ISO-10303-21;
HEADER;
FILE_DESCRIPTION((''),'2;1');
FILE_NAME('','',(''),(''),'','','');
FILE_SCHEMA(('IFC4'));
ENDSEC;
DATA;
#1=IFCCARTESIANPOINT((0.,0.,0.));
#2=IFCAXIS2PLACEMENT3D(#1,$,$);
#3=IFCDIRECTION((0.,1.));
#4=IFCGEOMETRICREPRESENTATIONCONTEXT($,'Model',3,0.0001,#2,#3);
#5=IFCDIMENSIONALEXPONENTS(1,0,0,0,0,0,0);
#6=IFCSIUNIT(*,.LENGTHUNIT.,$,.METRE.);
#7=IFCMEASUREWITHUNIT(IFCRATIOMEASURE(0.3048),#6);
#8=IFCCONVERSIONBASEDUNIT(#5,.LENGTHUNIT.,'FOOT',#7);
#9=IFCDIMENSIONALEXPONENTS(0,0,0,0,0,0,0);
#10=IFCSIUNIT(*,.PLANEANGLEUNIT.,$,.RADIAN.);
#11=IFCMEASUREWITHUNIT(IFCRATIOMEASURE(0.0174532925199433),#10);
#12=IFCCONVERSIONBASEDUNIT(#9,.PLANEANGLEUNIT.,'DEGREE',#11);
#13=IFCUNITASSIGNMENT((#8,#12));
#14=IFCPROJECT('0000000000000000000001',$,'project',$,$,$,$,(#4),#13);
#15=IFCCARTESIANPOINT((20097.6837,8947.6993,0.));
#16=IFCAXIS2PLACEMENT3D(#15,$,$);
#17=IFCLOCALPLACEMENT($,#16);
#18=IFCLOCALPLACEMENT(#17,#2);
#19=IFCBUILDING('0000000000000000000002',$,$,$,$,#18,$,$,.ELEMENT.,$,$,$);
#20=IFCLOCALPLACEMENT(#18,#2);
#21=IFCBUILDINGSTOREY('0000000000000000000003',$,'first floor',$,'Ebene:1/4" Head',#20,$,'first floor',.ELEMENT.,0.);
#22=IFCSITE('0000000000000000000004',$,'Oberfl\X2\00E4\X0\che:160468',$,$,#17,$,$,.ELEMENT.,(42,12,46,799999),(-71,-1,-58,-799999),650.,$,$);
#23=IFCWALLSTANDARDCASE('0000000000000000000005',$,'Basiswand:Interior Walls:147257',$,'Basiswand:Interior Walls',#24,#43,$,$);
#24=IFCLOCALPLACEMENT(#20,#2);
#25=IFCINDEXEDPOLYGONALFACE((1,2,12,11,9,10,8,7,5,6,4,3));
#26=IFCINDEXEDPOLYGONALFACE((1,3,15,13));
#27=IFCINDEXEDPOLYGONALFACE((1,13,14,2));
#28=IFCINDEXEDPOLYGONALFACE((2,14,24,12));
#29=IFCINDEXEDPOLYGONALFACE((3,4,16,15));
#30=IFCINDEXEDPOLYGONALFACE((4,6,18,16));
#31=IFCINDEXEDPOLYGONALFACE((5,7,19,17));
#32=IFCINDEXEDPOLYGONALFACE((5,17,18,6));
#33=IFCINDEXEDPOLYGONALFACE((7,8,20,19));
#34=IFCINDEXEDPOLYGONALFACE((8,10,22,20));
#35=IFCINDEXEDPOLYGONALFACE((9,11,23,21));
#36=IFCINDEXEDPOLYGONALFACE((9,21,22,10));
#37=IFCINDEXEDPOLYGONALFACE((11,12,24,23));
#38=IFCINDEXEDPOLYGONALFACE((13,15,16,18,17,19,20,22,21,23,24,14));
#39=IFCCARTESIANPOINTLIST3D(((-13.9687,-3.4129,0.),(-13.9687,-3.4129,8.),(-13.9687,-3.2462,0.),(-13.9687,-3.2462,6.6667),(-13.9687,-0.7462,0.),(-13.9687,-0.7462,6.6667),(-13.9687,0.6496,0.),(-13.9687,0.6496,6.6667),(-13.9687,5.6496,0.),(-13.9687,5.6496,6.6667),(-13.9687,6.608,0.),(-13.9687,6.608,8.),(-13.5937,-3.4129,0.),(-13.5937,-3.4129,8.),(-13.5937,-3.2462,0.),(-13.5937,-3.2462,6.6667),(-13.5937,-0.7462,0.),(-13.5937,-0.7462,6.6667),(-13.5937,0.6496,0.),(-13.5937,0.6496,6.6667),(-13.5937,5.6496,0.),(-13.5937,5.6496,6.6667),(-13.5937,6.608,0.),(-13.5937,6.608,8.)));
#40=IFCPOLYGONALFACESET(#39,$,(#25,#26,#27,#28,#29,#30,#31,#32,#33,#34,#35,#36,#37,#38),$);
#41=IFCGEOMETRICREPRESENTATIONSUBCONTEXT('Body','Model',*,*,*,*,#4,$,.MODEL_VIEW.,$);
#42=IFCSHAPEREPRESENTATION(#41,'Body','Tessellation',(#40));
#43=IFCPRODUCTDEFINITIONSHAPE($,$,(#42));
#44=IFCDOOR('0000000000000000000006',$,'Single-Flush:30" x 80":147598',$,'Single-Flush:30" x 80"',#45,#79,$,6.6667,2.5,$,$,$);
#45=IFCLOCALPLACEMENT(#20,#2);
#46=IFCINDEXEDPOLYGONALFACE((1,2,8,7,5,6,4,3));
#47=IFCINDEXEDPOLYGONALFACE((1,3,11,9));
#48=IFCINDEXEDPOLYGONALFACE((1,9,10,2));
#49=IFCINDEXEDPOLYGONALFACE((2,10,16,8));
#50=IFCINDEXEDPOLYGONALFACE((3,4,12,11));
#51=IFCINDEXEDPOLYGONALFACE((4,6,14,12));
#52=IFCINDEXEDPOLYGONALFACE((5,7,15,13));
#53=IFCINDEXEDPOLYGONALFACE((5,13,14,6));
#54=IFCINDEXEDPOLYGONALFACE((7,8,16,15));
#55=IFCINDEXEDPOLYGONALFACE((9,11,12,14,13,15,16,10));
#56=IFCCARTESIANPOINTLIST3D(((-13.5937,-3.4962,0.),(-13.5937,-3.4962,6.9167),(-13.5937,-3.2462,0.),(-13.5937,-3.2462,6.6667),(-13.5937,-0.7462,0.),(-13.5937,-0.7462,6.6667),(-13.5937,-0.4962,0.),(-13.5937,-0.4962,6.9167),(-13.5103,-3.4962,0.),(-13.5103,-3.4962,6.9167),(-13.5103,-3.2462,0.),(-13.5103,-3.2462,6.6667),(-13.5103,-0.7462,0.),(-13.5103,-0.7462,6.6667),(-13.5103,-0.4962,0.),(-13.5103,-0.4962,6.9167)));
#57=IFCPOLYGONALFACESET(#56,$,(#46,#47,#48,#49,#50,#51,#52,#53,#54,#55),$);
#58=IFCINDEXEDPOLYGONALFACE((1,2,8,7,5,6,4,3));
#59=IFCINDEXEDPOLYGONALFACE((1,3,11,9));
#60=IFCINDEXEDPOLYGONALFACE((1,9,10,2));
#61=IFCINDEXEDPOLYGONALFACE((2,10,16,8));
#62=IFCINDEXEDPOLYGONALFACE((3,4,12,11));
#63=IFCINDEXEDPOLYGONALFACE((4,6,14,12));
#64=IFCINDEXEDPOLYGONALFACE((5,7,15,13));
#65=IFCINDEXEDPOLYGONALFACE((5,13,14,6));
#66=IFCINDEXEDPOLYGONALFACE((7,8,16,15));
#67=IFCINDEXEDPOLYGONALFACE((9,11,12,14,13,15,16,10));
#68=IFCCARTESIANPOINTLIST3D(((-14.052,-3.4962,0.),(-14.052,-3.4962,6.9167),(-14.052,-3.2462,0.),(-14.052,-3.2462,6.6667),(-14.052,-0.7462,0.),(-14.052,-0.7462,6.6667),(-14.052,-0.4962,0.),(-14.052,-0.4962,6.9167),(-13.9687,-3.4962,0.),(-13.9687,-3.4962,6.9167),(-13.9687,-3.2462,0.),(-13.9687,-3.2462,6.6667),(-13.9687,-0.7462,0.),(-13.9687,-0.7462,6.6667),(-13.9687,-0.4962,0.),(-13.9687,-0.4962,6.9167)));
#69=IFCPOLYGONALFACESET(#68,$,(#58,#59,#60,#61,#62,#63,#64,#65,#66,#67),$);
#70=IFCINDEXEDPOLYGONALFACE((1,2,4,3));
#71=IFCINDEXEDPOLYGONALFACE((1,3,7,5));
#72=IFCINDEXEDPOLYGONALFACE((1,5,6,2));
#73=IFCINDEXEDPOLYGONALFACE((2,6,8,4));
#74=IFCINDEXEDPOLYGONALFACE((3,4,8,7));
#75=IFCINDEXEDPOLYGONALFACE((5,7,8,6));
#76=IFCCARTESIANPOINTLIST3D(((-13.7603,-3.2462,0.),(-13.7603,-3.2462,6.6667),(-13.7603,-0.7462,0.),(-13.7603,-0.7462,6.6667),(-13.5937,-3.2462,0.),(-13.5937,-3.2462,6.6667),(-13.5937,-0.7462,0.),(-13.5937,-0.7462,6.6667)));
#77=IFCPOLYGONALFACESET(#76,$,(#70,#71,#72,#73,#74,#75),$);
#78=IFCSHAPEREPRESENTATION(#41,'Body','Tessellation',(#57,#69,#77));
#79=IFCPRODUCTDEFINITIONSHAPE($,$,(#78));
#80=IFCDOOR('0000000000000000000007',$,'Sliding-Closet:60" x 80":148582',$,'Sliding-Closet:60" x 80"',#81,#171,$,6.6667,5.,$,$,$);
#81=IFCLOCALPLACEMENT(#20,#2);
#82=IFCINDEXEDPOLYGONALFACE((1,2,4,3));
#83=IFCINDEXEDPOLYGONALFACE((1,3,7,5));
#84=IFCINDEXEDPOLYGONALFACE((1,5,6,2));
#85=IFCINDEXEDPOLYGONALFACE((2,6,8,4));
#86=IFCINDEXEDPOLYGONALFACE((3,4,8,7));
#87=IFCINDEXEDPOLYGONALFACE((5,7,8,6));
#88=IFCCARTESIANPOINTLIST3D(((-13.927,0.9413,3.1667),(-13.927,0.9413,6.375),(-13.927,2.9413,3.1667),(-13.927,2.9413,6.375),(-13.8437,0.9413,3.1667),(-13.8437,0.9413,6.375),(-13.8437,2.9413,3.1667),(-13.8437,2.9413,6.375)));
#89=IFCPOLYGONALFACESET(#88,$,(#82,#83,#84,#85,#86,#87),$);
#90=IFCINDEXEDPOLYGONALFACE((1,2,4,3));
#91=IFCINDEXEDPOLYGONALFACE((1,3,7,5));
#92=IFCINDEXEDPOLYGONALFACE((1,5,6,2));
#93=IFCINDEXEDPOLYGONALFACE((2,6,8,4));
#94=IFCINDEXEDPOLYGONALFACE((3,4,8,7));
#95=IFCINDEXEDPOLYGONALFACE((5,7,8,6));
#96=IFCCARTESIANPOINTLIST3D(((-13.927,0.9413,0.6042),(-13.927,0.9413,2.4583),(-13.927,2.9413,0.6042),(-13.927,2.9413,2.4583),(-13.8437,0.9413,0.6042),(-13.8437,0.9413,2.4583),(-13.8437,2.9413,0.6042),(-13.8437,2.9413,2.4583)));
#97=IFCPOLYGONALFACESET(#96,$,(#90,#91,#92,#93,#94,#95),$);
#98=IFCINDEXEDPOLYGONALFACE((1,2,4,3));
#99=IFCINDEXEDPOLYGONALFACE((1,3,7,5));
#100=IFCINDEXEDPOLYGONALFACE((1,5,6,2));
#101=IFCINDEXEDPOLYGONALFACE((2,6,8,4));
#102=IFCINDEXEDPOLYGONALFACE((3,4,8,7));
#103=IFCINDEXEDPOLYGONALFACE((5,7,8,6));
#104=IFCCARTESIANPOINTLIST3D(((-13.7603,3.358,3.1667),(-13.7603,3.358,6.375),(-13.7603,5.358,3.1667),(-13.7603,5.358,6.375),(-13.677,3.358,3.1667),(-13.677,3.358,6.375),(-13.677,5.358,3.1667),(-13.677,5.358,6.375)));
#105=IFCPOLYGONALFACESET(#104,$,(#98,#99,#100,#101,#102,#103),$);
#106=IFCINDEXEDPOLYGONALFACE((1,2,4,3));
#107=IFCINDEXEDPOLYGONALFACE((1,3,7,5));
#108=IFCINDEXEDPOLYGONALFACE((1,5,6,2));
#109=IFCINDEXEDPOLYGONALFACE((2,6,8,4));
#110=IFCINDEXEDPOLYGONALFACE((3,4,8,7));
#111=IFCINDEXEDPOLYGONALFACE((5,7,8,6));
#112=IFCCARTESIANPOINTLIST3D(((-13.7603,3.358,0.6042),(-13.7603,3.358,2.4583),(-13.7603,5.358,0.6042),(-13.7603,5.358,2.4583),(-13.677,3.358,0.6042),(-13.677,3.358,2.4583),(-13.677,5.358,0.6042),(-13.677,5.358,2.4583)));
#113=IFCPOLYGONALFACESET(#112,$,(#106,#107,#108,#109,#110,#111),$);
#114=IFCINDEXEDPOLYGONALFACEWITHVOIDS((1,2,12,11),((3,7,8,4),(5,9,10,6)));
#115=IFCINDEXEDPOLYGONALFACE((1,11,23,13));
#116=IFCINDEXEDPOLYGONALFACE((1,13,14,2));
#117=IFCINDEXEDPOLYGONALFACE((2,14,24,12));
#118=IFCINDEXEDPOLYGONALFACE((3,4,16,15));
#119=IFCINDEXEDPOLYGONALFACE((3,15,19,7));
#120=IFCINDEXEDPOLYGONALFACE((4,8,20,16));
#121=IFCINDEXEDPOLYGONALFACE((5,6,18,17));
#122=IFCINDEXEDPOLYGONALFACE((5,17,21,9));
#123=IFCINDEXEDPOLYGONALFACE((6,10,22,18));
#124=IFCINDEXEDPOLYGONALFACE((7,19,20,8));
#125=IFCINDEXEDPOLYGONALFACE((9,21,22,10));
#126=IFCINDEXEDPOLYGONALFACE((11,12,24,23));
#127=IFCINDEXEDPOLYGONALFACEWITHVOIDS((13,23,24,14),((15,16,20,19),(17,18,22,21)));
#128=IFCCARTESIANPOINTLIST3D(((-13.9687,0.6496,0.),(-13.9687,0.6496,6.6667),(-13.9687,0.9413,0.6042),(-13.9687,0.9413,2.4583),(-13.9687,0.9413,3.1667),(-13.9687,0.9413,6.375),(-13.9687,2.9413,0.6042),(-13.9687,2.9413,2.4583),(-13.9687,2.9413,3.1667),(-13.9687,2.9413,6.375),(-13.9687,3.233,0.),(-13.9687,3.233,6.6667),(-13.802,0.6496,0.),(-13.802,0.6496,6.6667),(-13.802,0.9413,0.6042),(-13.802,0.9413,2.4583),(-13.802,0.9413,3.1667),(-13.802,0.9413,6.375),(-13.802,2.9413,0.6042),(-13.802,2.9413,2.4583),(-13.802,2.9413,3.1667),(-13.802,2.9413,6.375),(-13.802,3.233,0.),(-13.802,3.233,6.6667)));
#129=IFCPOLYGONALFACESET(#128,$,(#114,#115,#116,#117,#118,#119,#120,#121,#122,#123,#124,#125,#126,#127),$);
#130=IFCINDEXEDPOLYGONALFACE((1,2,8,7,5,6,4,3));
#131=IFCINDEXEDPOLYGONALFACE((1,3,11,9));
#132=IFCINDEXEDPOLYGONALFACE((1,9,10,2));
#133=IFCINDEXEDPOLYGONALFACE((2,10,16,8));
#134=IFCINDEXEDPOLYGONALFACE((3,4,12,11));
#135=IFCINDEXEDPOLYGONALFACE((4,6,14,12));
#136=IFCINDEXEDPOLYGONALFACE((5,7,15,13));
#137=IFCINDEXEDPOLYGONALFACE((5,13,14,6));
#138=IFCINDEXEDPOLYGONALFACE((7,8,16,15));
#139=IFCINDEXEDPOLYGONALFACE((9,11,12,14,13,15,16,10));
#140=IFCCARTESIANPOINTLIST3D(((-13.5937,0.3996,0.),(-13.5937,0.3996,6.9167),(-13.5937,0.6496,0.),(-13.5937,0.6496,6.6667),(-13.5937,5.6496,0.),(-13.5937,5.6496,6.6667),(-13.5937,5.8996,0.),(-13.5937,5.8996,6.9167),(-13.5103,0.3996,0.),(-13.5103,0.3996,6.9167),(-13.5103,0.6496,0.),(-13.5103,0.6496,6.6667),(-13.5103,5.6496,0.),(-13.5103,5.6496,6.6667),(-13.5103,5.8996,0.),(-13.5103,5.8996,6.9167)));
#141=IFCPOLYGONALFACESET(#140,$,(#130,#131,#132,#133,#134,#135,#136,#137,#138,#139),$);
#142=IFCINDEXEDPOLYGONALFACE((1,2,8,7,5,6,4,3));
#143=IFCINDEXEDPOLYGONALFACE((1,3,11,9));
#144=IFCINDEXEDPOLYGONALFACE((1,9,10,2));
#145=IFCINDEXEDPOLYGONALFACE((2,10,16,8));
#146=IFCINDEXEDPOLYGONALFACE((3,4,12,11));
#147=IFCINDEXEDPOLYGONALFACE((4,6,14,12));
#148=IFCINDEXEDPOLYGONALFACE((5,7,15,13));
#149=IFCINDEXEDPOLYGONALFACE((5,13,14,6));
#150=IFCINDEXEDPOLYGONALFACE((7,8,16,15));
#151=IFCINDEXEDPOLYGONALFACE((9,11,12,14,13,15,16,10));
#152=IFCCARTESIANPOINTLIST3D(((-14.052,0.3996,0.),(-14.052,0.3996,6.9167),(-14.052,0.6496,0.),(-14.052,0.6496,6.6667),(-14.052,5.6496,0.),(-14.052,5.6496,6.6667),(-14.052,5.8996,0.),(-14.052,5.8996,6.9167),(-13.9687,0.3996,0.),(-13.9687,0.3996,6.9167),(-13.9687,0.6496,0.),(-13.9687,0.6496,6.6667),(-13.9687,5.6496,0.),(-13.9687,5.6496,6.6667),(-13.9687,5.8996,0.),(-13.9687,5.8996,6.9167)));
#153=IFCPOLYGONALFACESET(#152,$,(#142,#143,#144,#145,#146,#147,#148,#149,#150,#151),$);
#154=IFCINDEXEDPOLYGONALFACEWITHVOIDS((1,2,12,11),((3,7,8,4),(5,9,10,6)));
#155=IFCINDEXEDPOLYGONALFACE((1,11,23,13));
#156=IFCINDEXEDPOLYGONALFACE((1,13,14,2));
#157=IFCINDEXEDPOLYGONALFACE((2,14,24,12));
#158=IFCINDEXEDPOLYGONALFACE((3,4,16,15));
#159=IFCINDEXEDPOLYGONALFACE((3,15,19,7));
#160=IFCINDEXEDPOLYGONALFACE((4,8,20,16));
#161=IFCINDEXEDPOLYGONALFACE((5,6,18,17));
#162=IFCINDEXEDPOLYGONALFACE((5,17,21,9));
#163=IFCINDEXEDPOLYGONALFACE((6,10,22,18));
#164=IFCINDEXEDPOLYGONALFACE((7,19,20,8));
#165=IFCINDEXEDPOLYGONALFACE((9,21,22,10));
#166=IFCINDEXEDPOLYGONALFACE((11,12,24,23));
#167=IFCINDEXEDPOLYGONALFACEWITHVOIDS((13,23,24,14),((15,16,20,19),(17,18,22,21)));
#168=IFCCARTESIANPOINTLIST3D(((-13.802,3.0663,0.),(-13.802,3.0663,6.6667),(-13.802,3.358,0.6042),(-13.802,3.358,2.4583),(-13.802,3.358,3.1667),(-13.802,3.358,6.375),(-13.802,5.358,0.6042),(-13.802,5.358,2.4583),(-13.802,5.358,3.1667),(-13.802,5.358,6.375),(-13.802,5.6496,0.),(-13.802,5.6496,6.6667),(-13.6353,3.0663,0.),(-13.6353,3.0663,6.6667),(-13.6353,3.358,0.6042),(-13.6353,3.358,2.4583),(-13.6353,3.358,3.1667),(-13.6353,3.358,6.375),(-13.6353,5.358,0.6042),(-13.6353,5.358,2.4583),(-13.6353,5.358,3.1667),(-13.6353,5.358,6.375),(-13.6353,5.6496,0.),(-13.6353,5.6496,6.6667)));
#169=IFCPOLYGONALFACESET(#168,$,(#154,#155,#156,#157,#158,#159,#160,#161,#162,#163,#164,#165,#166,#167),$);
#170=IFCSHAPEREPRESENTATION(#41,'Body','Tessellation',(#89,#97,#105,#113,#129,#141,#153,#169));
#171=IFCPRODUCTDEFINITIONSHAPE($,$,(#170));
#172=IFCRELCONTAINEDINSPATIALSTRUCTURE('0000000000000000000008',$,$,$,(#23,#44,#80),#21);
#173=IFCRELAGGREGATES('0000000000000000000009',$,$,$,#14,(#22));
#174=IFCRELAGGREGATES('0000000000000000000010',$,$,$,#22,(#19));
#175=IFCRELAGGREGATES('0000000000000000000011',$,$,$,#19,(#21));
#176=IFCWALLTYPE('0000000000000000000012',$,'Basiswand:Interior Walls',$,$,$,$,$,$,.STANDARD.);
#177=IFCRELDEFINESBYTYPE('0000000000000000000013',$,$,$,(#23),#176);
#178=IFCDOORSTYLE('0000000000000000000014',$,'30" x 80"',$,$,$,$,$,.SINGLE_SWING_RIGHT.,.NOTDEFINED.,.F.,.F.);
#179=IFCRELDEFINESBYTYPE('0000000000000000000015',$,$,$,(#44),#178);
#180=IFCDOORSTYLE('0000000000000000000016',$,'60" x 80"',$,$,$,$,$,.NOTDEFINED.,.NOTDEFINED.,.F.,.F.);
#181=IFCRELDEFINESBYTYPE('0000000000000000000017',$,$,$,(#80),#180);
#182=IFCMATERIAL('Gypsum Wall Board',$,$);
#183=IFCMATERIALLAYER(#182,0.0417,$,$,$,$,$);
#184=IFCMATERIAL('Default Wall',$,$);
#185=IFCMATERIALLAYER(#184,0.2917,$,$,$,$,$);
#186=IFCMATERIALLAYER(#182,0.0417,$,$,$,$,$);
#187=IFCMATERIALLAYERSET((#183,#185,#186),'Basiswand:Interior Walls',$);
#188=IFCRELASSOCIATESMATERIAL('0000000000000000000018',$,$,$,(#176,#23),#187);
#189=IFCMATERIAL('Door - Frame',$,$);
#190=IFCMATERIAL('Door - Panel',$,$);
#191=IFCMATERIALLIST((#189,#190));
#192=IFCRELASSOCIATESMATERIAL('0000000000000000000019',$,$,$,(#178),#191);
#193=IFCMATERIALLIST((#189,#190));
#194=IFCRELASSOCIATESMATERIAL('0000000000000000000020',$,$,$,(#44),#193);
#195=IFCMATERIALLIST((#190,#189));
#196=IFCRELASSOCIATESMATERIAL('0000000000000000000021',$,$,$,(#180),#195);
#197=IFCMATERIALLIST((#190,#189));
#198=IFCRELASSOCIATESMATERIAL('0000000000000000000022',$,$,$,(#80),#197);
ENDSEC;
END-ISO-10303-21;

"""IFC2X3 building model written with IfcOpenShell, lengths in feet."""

from ifc_helpers import new_model, entity, si_unit, converted_unit, direction, frame, frame_2d, origin, origin_2d_with_axis, place, context, subcontext, project, spatial, polyline, rectangle, outline, extrude, source, transform, mapped, material, material_list, layer, layer_set, layer_usage, type_object, type_shapes, element, fill, save


model = new_model("IFC2X3")

# Units and contexts
model_context = context("Model", 3, precision=0.0001, world=origin(), true_north=direction((0.0, 1.0)))
body_context = subcontext(model_context, "Body", "Model", "MODEL_VIEW")
ifc_project = project(units=[converted_unit("LENGTHUNIT", "FOOT", entity("IfcRatioMeasure", 0.3048), si_unit("LENGTHUNIT", "METRE"), dimensions=[1, 0, 0, 0, 0, 0, 0]), converted_unit("PLANEANGLEUNIT", "DEGREE", entity("IfcRatioMeasure", 0.0174532925199433), si_unit("PLANEANGLEUNIT", "RADIAN"), dimensions=[0, 0, 0, 0, 0, 0, 0])], contexts=[model_context])

# Site, building, storey
site_placement = place(None, frame((20097.6837, 8947.6993, 0.0)))
site = spatial("IfcSite", under=ifc_project, at=site_placement, Name="Oberfläche:160468", CompositionType="ELEMENT", RefLatitude=(42, 12, 46, 799999), RefLongitude=(-71, -1, -58, -799999), RefElevation=650.0)
building_placement = place(site_placement, origin())
building = spatial("IfcBuilding", under=site, at=building_placement, CompositionType="ELEMENT")
storey_placement = place(building_placement, origin())
storey = spatial("IfcBuildingStorey", under=building, at=storey_placement, Name="first floor", ObjectType="Ebene:1/4\" Head", LongName="first floor", CompositionType="ELEMENT", Elevation=0.0)

# Shared definitions
ifc_material_1 = material(Name="Gypsum Wall Board")

# Shared definitions
ifc_layer_1 = layer(ifc_material_1, 0.0417)
ifc_material_2 = material(Name="Default Wall")
ifc_layer_2 = layer(ifc_material_2, 0.2917)
ifc_layer_3 = layer(ifc_material_1, 0.0417)
ifc_layer_set_1 = layer_set([ifc_layer_1, ifc_layer_2, ifc_layer_3], Name="Basiswand:Interior Walls")
wall_type_1 = type_object("IfcWallType", Name="Basiswand:Interior Walls", PredefinedType="STANDARD", material=ifc_layer_set_1)
ifc_material_3 = material(Name="Door - Frame")
ifc_material_4 = material(Name="Door - Panel")
ifc_material_list_1 = material_list([ifc_material_3, ifc_material_4])
door_style_1 = type_object("IfcDoorStyle", Name="30\" x 80\"", ConstructionType="NOTDEFINED", OperationType="SINGLE_SWING_RIGHT", ParameterTakesPrecedence=False, Sizeable=False, material=ifc_material_list_1)
shared_shape_1 = source(origin(), body_context, "Body", "SweptSolid", [
    extrude(outline(polyline([(-1.5, -3.5208), (1.5, -3.5208), (1.5, 3.3958), (1.25, 3.3958), (1.25, -3.2708), (-1.25, -3.2708), (-1.25, 3.3958), (-1.5, 3.3958), (-1.5, -3.5208)])), frame((1.25, 0.375, 3.3958), z_axis=(0.0, 1.0, 0.0), x_axis=(1.0, 0.0, 0.0)), (0.0, 0.0, 1.0), 0.0833),
    extrude(outline(polyline([(-3.5208, -1.5), (3.3958, -1.5), (3.3958, -1.25), (-3.2708, -1.25), (-3.2708, 1.25), (3.3958, 1.25), (3.3958, 1.5), (-3.5208, 1.5), (-3.5208, -1.5)])), frame((1.25, -0.0833, 3.3958), z_axis=(0.0, 1.0, 0.0), x_axis=(0.0, 0.0, -1.0)), (0.0, 0.0, 1.0), 0.0833),
    extrude(rectangle(XDim=0.1667, YDim=2.5, at=origin_2d_with_axis()), frame((1.25, 0.2917, 0.0), z_axis=(0.0, 0.0, 1.0), x_axis=(0.0, 1.0, 0.0)), (0.0, 0.0, 1.0), 6.6667),
])
type_shapes(door_style_1, [shared_shape_1])

# Wall, openings, doors
ifc_layer_usage_1 = layer_usage(ifc_layer_set_1, "AXIS2", "NEGATIVE", 0.1875)
wall_1_placement = place(storey_placement, frame((-13.7812, -3.4129, 0.0), z_axis=(0.0, 0.0, 1.0), x_axis=(0.0, 1.0, 0.0)))
wall_1 = element("IfcWallStandardCase", 1, at=wall_1_placement, inside=storey, type_object=wall_type_1, material=ifc_layer_usage_1, Name="Basiswand:Interior Walls:147257", ObjectType="Basiswand:Interior Walls", context=body_context, shape_type="SweptSolid", body=[
    extrude(rectangle(XDim=10.0208, YDim=0.375, at=frame_2d((5.0104, 0.0), x_axis=(-1.0, 0.0))), origin(), (0.0, 0.0, 1.0), 8.0),
])
opening_1_placement = place(wall_1_placement, frame((2.6667, 0.1875, 0.0)))
opening_1 = element("IfcOpeningElement", 2, at=opening_1_placement, cuts=wall_1, ObjectType="Opening", context=body_context, shape_type="SweptSolid", body=[
    extrude(rectangle(XDim=2.5, YDim=6.6667, at=frame_2d((3.3333, 1.25), x_axis=(0.0, 1.0))), frame((0.0, 0.0, 0.0), z_axis=(0.0, -1.0, 0.0), x_axis=(0.0, 0.0, 1.0)), (0.0, 0.0, 1.0), 0.375),
])
opening_2_placement = place(wall_1_placement, frame((4.0625, -0.1875, 0.0)))
opening_2 = element("IfcOpeningElement", 3, at=opening_2_placement, cuts=wall_1, ObjectType="Opening", context=body_context, shape_type="SweptSolid", body=[
    extrude(rectangle(XDim=6.6667, YDim=5.0, at=frame_2d((3.3333, 2.5), x_axis=(-1.0, 0.0))), frame((0.0, 0.0, 0.0), z_axis=(0.0, 1.0, 0.0), x_axis=(0.0, 0.0, 1.0)), (0.0, 0.0, 1.0), 0.375),
])
ifc_material_list_2 = material_list([ifc_material_3, ifc_material_4])
door_1_placement = place(opening_1_placement, frame((0.0, 0.0, 0.0), z_axis=(0.0, 0.0, 1.0), x_axis=(-1.0, 0.0, 0.0)))
door_1 = element("IfcDoor", 4, at=door_1_placement, inside=storey, type_object=door_style_1, material=ifc_material_list_2, Name="Single-Flush:30\" x 80\":147598", ObjectType="Single-Flush:30\" x 80\"", OverallHeight=6.6667, OverallWidth=2.5, context=body_context, shape_type="MappedRepresentation", body=[
    mapped(shared_shape_1, transform((0.0, 0.0, 0.0), scale=1.0)),
])
fill(opening_1, door_1)
ifc_material_list_3 = material_list([ifc_material_4, ifc_material_3])
ifc_material_list_4 = material_list([ifc_material_4, ifc_material_3])
door_style_2 = type_object("IfcDoorStyle", Name="60\" x 80\"", ConstructionType="NOTDEFINED", OperationType="NOTDEFINED", ParameterTakesPrecedence=False, Sizeable=False, material=ifc_material_list_4)
shared_shape_2 = source(origin(), body_context, "Body", "SweptSolid", [
    extrude(rectangle(XDim=0.0833, YDim=2.0, at=origin_2d_with_axis()), frame((1.2917, 0.2917, 3.1667), z_axis=(0.0, 0.0, 1.0), x_axis=(0.0, 1.0, 0.0)), (0.0, 0.0, 1.0), 3.2083),
    extrude(rectangle(XDim=0.0833, YDim=2.0, at=frame_2d((0.0, 0.0), x_axis=(1.0, 0.0))), frame((1.2917, 0.2917, 0.6042), z_axis=(0.0, 0.0, 1.0), x_axis=(0.0, 1.0, 0.0)), (0.0, 0.0, 1.0), 1.8542),
    extrude(rectangle(XDim=0.0833, YDim=2.0, at=origin_2d_with_axis()), frame((3.7083, 0.125, 3.1667), z_axis=(0.0, 0.0, 1.0), x_axis=(0.0, -1.0, 0.0)), (0.0, 0.0, 1.0), 3.2083),
    extrude(rectangle(XDim=0.0833, YDim=2.0, at=origin_2d_with_axis()), frame((3.7083, 0.125, 0.6042), z_axis=(0.0, 0.0, 1.0), x_axis=(0.0, -1.0, 0.0)), (0.0, 0.0, 1.0), 1.8542),
    extrude(outline(polyline([(-3.3333, -1.2917), (3.3333, -1.2917), (3.3333, 1.2917), (-3.3333, 1.2917), (-3.3333, -1.2917)]), holes=[polyline([(2.7292, 1.0), (2.7292, -1.0), (0.875, -1.0), (0.875, 1.0), (2.7292, 1.0)]), polyline([(0.1667, 1.0), (0.1667, -1.0), (-3.0417, -1.0), (-3.0417, 1.0), (0.1667, 1.0)])]), frame((1.2917, 0.2083, 3.3333), z_axis=(0.0, 1.0, 0.0), x_axis=(0.0, 0.0, -1.0)), (0.0, 0.0, 1.0), 0.1667),
    extrude(outline(polyline([(-3.3958, -2.75), (3.5208, -2.75), (3.5208, 2.75), (-3.3958, 2.75), (-3.3958, 2.5), (3.2708, 2.5), (3.2708, -2.5), (-3.3958, -2.5), (-3.3958, -2.75)])), frame((2.5, -0.0833, 3.3958), z_axis=(0.0, 1.0, 0.0), x_axis=(0.0, 0.0, 1.0)), (0.0, 0.0, 1.0), 0.0833),
    extrude(outline(polyline([(-2.75, -3.3958), (-2.5, -3.3958), (-2.5, 3.2708), (2.5, 3.2708), (2.5, -3.3958), (2.75, -3.3958), (2.75, 3.5208), (-2.75, 3.5208), (-2.75, -3.3958)])), frame((2.5, 0.375, 3.3958), z_axis=(0.0, 1.0, 0.0), x_axis=(-1.0, 0.0, 0.0)), (0.0, 0.0, 1.0), 0.0833),
    extrude(outline(polyline([(-1.2917, -3.3333), (1.2917, -3.3333), (1.2917, 3.3333), (-1.2917, 3.3333), (-1.2917, -3.3333)]), holes=[polyline([(1.0, 0.1667), (1.0, -3.0417), (-1.0, -3.0417), (-1.0, 0.1667), (1.0, 0.1667)]), polyline([(1.0, 2.7292), (1.0, 0.875), (-1.0, 0.875), (-1.0, 2.7292), (1.0, 2.7292)])]), frame((3.7083, 0.0417, 3.3333), z_axis=(0.0, 1.0, 0.0), x_axis=(1.0, 0.0, 0.0)), (0.0, 0.0, 1.0), 0.1667),
])
type_shapes(door_style_2, [shared_shape_2])
door_2_placement = place(opening_2_placement, origin())
door_2 = element("IfcDoor", 5, at=door_2_placement, inside=storey, type_object=door_style_2, material=ifc_material_list_3, Name="Sliding-Closet:60\" x 80\":148582", ObjectType="Sliding-Closet:60\" x 80\"", OverallHeight=6.6667, OverallWidth=5.0, context=body_context, shape_type="MappedRepresentation", body=[
    mapped(shared_shape_2, transform((0.0, 0.0, 0.0), scale=1.0)),
])
fill(opening_2, door_2)

save(model, "model.ifc")
